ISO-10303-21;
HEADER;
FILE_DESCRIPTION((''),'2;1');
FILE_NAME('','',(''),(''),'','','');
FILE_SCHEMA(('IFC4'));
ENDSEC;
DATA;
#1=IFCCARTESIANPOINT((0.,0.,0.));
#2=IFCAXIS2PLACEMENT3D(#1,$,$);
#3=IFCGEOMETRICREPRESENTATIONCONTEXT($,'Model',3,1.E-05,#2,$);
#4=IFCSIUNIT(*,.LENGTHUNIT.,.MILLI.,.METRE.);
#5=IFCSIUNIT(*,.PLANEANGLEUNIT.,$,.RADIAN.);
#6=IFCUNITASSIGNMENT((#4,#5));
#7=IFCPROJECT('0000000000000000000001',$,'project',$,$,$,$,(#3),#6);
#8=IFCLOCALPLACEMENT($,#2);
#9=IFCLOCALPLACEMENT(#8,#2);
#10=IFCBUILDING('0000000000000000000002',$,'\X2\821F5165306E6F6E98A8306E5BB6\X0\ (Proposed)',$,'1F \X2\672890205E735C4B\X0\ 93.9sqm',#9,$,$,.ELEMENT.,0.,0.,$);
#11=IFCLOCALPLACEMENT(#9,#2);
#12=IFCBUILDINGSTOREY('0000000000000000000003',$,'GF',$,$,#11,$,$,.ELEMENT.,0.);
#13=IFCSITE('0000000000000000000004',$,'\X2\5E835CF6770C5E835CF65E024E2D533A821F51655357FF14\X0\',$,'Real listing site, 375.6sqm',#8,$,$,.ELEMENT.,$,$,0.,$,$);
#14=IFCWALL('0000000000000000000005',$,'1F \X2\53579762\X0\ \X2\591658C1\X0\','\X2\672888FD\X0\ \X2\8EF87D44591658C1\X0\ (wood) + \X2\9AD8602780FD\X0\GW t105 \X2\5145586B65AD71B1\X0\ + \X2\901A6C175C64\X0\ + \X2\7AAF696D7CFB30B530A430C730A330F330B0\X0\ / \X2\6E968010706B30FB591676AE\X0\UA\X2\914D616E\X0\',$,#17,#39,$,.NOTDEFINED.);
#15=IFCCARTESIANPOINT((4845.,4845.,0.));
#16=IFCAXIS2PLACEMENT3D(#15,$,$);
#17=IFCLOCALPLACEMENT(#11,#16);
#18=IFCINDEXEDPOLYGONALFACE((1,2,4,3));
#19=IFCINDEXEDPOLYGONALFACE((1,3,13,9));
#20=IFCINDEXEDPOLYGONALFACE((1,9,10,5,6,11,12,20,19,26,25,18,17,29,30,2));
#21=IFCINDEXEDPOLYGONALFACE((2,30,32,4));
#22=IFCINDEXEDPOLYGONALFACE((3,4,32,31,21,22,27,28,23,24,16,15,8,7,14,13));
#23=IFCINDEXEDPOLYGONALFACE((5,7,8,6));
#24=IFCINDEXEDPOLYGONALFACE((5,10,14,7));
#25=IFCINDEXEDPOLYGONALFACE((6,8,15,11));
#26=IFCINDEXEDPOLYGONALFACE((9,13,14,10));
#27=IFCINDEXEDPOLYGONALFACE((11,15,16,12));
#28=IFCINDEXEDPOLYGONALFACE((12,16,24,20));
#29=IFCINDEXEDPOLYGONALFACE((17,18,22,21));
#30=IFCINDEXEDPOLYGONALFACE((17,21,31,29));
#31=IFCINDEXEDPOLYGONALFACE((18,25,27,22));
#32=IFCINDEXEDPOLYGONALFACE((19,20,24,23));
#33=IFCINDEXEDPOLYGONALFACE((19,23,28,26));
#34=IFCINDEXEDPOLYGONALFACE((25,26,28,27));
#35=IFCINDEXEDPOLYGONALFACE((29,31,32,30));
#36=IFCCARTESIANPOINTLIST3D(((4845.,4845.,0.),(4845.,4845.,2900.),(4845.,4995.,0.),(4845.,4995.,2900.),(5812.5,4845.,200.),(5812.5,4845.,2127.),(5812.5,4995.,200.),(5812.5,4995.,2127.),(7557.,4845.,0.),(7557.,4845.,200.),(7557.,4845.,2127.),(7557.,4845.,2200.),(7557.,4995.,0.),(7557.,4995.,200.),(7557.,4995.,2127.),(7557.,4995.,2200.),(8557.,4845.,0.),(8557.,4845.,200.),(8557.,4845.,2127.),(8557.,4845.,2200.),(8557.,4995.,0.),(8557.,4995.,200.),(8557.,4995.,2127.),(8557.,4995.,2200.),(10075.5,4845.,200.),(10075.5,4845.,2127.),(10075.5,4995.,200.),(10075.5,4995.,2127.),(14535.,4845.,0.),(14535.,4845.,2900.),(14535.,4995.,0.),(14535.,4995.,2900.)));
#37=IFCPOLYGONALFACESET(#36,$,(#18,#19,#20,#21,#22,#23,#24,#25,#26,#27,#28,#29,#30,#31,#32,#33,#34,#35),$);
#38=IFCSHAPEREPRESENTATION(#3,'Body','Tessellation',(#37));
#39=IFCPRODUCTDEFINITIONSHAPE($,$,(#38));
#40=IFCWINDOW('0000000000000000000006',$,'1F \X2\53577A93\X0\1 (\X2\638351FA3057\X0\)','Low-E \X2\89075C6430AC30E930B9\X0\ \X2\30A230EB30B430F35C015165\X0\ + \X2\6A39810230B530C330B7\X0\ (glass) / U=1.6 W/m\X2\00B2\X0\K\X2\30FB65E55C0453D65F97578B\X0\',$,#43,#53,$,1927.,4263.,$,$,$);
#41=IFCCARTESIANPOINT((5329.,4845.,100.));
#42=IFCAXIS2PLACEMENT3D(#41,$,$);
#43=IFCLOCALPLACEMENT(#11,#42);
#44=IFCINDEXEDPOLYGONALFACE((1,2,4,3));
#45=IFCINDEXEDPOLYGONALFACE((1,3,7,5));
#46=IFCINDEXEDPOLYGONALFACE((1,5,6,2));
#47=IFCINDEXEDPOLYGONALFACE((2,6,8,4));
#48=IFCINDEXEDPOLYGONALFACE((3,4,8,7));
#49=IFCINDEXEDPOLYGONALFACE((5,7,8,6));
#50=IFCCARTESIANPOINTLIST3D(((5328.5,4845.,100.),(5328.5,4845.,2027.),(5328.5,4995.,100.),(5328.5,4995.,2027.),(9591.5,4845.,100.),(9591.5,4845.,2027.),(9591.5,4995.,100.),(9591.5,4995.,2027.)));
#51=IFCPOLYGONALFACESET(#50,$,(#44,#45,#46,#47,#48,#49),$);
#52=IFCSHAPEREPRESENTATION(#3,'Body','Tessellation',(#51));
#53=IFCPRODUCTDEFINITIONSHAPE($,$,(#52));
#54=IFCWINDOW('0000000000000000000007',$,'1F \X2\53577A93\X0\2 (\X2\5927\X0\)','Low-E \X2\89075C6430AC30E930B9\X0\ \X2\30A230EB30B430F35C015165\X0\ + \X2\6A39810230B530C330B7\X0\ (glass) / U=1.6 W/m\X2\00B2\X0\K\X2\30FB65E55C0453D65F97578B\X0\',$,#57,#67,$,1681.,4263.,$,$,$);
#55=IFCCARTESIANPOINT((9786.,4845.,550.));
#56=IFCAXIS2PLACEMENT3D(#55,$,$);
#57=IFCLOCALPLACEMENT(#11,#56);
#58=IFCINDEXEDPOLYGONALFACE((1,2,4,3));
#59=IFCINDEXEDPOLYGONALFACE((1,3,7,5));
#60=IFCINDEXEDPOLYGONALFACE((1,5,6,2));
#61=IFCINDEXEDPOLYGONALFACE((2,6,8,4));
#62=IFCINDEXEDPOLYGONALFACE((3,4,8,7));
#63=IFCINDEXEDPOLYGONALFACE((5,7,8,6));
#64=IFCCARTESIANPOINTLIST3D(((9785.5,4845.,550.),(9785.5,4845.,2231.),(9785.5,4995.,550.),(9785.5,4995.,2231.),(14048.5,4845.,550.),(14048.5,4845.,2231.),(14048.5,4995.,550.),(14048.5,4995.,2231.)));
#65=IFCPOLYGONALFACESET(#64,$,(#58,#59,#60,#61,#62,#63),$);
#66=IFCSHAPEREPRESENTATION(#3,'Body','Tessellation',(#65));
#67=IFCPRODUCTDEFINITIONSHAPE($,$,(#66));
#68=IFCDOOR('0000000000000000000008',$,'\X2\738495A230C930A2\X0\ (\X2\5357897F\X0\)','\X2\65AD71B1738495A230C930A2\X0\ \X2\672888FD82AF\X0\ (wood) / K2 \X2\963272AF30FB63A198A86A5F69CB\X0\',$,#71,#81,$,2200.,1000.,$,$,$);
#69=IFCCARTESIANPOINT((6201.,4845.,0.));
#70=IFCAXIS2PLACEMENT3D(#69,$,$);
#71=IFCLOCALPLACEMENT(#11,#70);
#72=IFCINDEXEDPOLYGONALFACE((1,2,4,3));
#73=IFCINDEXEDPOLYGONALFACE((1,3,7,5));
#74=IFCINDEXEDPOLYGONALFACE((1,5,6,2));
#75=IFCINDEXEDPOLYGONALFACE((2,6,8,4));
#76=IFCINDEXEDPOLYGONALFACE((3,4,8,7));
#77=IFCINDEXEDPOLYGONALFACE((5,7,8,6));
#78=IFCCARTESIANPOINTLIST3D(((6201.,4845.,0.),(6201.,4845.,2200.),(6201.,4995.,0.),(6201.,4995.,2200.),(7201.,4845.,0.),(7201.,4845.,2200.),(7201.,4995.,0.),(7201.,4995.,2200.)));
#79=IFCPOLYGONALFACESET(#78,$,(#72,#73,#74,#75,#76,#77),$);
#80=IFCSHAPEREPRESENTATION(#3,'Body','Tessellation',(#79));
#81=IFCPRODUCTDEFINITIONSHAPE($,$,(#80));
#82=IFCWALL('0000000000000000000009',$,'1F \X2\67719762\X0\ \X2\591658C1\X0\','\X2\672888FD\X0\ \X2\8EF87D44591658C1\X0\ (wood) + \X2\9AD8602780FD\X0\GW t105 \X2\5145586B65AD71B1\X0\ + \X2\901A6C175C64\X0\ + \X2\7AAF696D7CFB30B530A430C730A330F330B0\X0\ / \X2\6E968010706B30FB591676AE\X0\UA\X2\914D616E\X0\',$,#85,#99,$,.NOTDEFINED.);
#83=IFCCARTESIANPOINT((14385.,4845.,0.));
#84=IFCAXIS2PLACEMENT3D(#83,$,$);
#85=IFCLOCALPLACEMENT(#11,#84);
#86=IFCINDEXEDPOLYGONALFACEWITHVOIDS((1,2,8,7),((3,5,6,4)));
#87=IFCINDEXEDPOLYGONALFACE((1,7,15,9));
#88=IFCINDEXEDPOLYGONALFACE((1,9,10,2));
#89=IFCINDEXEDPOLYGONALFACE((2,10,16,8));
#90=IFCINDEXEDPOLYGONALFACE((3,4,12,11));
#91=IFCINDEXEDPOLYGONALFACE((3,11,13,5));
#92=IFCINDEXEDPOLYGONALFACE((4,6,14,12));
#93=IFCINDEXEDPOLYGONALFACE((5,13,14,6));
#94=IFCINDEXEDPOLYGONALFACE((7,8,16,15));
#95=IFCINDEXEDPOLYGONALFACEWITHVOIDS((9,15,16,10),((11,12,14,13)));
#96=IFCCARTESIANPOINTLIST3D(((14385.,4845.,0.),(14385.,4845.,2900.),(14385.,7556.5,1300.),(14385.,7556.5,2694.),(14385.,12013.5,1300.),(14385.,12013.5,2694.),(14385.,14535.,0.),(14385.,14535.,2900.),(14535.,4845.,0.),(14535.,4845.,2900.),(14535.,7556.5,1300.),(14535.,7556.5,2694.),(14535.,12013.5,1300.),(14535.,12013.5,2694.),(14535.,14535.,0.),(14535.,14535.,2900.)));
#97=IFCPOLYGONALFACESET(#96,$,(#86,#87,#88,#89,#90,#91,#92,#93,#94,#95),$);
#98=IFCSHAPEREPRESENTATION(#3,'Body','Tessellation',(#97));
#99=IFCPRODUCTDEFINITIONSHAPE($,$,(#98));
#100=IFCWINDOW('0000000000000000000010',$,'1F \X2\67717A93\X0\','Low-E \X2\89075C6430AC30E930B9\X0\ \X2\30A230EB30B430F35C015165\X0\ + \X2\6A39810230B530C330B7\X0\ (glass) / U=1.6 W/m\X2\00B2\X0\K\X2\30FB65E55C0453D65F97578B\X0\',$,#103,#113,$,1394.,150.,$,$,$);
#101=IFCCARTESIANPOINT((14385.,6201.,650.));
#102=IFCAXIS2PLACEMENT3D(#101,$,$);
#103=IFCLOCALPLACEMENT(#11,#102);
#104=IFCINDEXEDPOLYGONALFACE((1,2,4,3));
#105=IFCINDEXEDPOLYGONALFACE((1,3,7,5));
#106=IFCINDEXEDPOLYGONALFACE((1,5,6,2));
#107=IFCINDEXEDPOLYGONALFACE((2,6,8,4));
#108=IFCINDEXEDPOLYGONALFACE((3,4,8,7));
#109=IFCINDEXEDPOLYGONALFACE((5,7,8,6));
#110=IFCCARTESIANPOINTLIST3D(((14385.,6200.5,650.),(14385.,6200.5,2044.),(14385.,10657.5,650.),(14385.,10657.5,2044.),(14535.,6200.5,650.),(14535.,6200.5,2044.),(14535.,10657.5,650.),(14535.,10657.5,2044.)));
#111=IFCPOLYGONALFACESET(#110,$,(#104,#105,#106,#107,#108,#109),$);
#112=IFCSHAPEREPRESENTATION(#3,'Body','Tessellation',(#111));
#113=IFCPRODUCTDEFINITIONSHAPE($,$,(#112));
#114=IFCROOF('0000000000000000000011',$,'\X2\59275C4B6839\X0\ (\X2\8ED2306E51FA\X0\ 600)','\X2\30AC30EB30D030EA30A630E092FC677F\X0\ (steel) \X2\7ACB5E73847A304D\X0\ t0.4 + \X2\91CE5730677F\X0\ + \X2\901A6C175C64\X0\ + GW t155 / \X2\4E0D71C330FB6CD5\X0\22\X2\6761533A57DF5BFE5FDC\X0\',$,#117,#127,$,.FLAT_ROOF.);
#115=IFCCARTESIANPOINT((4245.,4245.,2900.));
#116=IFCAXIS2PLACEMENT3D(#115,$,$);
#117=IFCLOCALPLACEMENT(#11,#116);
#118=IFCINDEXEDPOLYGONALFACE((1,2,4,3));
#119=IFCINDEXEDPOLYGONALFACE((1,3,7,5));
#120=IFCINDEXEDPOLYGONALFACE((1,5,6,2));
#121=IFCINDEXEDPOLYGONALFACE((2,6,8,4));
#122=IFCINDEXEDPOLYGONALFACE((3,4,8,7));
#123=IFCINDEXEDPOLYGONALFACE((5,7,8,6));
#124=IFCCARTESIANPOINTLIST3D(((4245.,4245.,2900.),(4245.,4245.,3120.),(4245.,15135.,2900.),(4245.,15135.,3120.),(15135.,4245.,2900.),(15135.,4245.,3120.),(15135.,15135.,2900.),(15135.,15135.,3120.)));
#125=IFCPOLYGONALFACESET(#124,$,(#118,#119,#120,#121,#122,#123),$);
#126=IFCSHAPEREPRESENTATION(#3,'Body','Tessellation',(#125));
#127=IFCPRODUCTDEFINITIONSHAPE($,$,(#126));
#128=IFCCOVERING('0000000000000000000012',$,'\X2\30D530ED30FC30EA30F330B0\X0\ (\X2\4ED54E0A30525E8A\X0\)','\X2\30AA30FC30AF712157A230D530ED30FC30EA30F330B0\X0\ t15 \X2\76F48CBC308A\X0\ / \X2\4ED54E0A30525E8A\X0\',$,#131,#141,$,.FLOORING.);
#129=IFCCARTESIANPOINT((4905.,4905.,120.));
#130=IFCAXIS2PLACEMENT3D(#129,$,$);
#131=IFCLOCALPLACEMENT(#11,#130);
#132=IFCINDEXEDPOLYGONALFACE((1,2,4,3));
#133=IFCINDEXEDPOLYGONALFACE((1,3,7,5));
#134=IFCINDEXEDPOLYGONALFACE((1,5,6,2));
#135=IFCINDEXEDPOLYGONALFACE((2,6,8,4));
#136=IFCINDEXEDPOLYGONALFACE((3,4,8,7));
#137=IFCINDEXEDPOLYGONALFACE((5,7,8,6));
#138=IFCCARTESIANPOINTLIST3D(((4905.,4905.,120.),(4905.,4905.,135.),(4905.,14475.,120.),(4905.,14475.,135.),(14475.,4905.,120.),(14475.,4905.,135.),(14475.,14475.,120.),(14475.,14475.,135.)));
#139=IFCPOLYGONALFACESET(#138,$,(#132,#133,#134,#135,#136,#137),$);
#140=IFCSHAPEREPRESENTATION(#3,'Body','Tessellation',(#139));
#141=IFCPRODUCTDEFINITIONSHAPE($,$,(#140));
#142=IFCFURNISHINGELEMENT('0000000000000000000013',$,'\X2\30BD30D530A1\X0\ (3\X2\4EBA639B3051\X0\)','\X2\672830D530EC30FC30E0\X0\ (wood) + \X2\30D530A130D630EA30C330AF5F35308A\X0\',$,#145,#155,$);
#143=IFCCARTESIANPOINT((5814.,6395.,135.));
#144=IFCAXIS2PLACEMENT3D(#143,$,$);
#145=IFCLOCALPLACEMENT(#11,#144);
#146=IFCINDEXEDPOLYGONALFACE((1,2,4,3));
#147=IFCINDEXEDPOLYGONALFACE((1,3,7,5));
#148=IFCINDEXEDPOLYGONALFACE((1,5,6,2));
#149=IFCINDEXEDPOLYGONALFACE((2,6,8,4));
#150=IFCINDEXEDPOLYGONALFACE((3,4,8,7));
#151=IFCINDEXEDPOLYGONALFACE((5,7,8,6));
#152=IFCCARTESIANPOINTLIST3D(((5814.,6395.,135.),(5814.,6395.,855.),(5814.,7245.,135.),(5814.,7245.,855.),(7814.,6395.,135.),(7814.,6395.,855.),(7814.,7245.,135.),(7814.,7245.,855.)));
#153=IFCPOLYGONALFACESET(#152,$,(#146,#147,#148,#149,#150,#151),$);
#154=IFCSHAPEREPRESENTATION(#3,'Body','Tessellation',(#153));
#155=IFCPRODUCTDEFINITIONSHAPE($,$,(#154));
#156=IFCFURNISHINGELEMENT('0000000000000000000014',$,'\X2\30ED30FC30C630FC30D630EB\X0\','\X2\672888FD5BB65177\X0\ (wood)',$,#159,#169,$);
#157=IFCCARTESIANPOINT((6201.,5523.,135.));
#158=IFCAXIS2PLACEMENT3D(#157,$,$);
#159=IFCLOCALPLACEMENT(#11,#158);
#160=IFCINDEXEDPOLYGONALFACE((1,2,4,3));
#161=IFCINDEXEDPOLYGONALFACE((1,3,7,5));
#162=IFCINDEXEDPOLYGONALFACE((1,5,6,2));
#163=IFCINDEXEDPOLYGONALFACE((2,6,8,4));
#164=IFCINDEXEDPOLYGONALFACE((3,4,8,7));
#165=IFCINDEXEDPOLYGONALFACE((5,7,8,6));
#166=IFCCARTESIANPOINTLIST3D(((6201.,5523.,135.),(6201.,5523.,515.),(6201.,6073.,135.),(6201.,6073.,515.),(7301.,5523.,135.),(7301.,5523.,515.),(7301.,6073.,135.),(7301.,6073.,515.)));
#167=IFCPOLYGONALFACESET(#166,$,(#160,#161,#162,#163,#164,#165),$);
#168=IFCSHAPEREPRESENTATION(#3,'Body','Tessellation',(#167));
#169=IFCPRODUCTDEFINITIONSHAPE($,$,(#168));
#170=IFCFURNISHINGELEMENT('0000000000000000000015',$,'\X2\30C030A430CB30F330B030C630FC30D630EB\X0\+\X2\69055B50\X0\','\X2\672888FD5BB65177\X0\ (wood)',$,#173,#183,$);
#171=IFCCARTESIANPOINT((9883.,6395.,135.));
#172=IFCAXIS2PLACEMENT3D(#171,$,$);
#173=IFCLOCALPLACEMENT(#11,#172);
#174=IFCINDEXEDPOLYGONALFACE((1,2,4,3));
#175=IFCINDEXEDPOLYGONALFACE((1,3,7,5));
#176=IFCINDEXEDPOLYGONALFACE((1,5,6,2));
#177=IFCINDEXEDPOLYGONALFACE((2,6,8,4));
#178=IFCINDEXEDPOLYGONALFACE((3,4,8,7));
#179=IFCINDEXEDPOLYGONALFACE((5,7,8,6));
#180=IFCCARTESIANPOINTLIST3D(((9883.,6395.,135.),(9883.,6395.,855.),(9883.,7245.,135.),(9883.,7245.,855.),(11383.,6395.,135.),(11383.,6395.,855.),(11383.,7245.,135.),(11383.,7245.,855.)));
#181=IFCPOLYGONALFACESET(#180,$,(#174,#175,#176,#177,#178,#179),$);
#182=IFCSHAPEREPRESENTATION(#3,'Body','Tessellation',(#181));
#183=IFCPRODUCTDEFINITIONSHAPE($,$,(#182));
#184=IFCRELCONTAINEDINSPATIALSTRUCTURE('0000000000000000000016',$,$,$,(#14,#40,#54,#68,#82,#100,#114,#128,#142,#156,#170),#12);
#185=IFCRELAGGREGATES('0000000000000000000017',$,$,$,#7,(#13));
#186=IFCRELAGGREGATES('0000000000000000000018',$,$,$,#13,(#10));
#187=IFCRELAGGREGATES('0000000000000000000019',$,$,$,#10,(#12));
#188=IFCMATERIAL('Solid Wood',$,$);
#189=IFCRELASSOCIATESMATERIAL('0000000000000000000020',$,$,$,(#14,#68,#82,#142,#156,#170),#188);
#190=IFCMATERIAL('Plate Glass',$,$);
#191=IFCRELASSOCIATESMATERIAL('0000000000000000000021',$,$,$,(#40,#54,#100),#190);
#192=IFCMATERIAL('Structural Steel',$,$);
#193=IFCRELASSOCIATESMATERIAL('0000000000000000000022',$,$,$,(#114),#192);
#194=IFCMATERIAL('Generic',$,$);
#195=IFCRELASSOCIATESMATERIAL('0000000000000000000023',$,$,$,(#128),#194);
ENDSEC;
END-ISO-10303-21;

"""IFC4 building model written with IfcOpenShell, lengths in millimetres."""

from ifc_helpers import new_model, si_unit, frame, frame_2d, origin, place, context, project, spatial, rectangle, extrude, material, element, fill, save


model = new_model("IFC4")

# Units and contexts
model_context = context("Model", 3, precision=1e-05, world=origin())
ifc_project = project(units=[si_unit("LENGTHUNIT", "METRE", prefix="MILLI"), si_unit("PLANEANGLEUNIT", "RADIAN")], contexts=[model_context])

# Site, building, storey
site_placement = place(None, origin())
site = spatial("IfcSite", under=ifc_project, at=site_placement, Name="広島県広島市中区舟入南４", ObjectType="Real listing site, 375.6sqm", CompositionType="ELEMENT", RefElevation=0.0)
building_placement = place(site_placement, origin())
building = spatial("IfcBuilding", under=site, at=building_placement, Name="舟入の潮風の家 (Proposed)", ObjectType="1F 木造平屋 93.9sqm", CompositionType="ELEMENT", ElevationOfRefHeight=0.0, ElevationOfTerrain=0.0)
storey_placement = place(building_placement, origin())
storey = spatial("IfcBuildingStorey", under=building, at=storey_placement, Name="GF", CompositionType="ELEMENT", Elevation=0.0)

# Shared definitions
ifc_material_1 = material(Name="Solid Wood")

# Wall, openings, windows, door
wall_1_placement = place(storey_placement, frame((4845.0, 4845.0, 0.0)))
wall_1 = element("IfcWall", 1, at=wall_1_placement, inside=storey, material=ifc_material_1, Name="1F 南面 外壁", Description="木製 軸組外壁 (wood) + 高性能GW t105 充填断熱 + 通気層 + 窯業系サイディング / 準耐火・外皮UA配慮", PredefinedType="NOTDEFINED", context=model_context, shape_type="SweptSolid", body=[
    extrude(rectangle(XDim=9690.0, YDim=150.0, at=frame_2d((4845.0, 75.0))), frame((4845.0, 4845.0, 0.0)), (0.0, 0.0, 1.0), 2900.0),
])
opening_1_placement = place(storey_placement, frame((5329.0, 4845.0, 100.0)))
opening_1 = element("IfcOpeningElement", 2, at=opening_1_placement, cuts=wall_1, PredefinedType="NOTDEFINED", context=model_context, shape_type="SweptSolid", body=[
    extrude(rectangle(XDim=4263.0, YDim=150.0, at=frame_2d((2131.0, 75.0))), frame((5329.0, 4845.0, 100.0)), (0.0, 0.0, 1.0), 1927.0),
])
opening_2_placement = place(storey_placement, frame((9786.0, 4845.0, 550.0)))
opening_2 = element("IfcOpeningElement", 3, at=opening_2_placement, cuts=wall_1, PredefinedType="NOTDEFINED", context=model_context, shape_type="SweptSolid", body=[
    extrude(rectangle(XDim=4263.0, YDim=150.0, at=frame_2d((2131.0, 75.0))), frame((9786.0, 4845.0, 550.0)), (0.0, 0.0, 1.0), 1681.0),
])
opening_3_placement = place(storey_placement, frame((6201.0, 4845.0, 0.0)))
opening_3 = element("IfcOpeningElement", 4, at=opening_3_placement, cuts=wall_1, PredefinedType="NOTDEFINED", context=model_context, shape_type="SweptSolid", body=[
    extrude(rectangle(XDim=1000.0, YDim=150.0, at=frame_2d((500.0, 75.0))), frame((6201.0, 4845.0, 0.0)), (0.0, 0.0, 1.0), 2200.0),
])
ifc_material_2 = material(Name="Plate Glass")
window_1_placement = place(storey_placement, frame((5329.0, 4845.0, 100.0)))
window_1 = element("IfcWindow", 5, at=window_1_placement, inside=storey, material=ifc_material_2, Name="1F 南窓1 (掃出し)", Description="Low-E 複層ガラス アルゴン封入 + 樹脂サッシ (glass) / U=1.6 W/m²K・日射取得型", OverallHeight=1927.0, OverallWidth=4263.0, context=model_context, shape_type="SweptSolid", body=[
    extrude(rectangle(XDim=4263.0, YDim=150.0, at=frame_2d((2131.0, 75.0))), frame((5329.0, 4845.0, 100.0)), (0.0, 0.0, 1.0), 1927.0),
])
fill(opening_1, window_1)
window_2_placement = place(storey_placement, frame((9786.0, 4845.0, 550.0)))
window_2 = element("IfcWindow", 6, at=window_2_placement, inside=storey, material=ifc_material_2, Name="1F 南窓2 (大)", Description="Low-E 複層ガラス アルゴン封入 + 樹脂サッシ (glass) / U=1.6 W/m²K・日射取得型", OverallHeight=1681.0, OverallWidth=4263.0, context=model_context, shape_type="SweptSolid", body=[
    extrude(rectangle(XDim=4263.0, YDim=150.0, at=frame_2d((2131.0, 75.0))), frame((9786.0, 4845.0, 550.0)), (0.0, 0.0, 1.0), 1681.0),
])
fill(opening_2, window_2)
door_placement = place(storey_placement, frame((6201.0, 4845.0, 0.0)))
door = element("IfcDoor", 7, at=door_placement, inside=storey, material=ifc_material_1, Name="玄関ドア (南西)", Description="断熱玄関ドア 木製芯 (wood) / K2 防犯・採風機構", OverallHeight=2200.0, OverallWidth=1000.0, context=model_context, shape_type="SweptSolid", body=[
    extrude(rectangle(XDim=1000.0, YDim=150.0, at=frame_2d((500.0, 75.0))), frame((6201.0, 4845.0, 0.0)), (0.0, 0.0, 1.0), 2200.0),
])
fill(opening_3, door)

# Wall, opening, window
wall_2_placement = place(storey_placement, frame((14385.0, 4845.0, 0.0)))
wall_2 = element("IfcWall", 8, at=wall_2_placement, inside=storey, material=ifc_material_1, Name="1F 東面 外壁", Description="木製 軸組外壁 (wood) + 高性能GW t105 充填断熱 + 通気層 + 窯業系サイディング / 準耐火・外皮UA配慮", PredefinedType="NOTDEFINED", context=model_context, shape_type="SweptSolid", body=[
    extrude(rectangle(XDim=150.0, YDim=9690.0, at=frame_2d((75.0, 4845.0))), frame((14385.0, 4845.0, 0.0)), (0.0, 0.0, 1.0), 2900.0),
])
opening_4_placement = place(storey_placement, frame((14385.0, 6201.0, 650.0)))
opening_4 = element("IfcOpeningElement", 9, at=opening_4_placement, cuts=wall_2, PredefinedType="NOTDEFINED", context=model_context, shape_type="SweptSolid", body=[
    extrude(rectangle(XDim=150.0, YDim=4457.0, at=frame_2d((75.0, 2228.0))), frame((14385.0, 6201.0, 650.0)), (0.0, 0.0, 1.0), 1394.0),
])
window_3_placement = place(storey_placement, frame((14385.0, 6201.0, 650.0)))
window_3 = element("IfcWindow", 10, at=window_3_placement, inside=storey, material=ifc_material_2, Name="1F 東窓", Description="Low-E 複層ガラス アルゴン封入 + 樹脂サッシ (glass) / U=1.6 W/m²K・日射取得型", OverallHeight=1394.0, OverallWidth=150.0, context=model_context, shape_type="SweptSolid", body=[
    extrude(rectangle(XDim=150.0, YDim=4457.0, at=frame_2d((75.0, 2228.0))), frame((14385.0, 6201.0, 650.0)), (0.0, 0.0, 1.0), 1394.0),
])
fill(opening_4, window_3)

# Roof
ifc_material_3 = material(Name="Structural Steel")
roof_placement = place(storey_placement, frame((4245.0, 4245.0, 2900.0)))
element("IfcRoof", 11, at=roof_placement, inside=storey, material=ifc_material_3, Name="大屋根 (軒の出 600)", Description="ガルバリウム鋼板 (steel) 立平葺き t0.4 + 野地板 + 通気層 + GW t155 / 不燃・法22条区域対応", PredefinedType="FLAT_ROOF", context=model_context, shape_type="SweptSolid", body=[
    extrude(rectangle(XDim=10890.0, YDim=10890.0, at=frame_2d((5445.0, 5445.0))), frame((4245.0, 4245.0, 2900.0)), (0.0, 0.0, 1.0), 220.0),
])

# Covering
ifc_material_4 = material(Name="Generic")
covering_placement = place(storey_placement, frame((4905.0, 4905.0, 120.0)))
element("IfcCovering", 12, at=covering_placement, inside=storey, material=ifc_material_4, Name="フローリング (仕上げ床)", Description="オーク無垢フローリング t15 直貼り / 仕上げ床", PredefinedType="FLOORING", context=model_context, shape_type="SweptSolid", body=[
    extrude(rectangle(XDim=9570.0, YDim=9570.0, at=frame_2d((4785.0, 4785.0))), frame((4905.0, 4905.0, 120.0)), (0.0, 0.0, 1.0), 15.0),
])

# Furnishing elements
furnishing_1_placement = place(storey_placement, frame((5814.0, 6395.0, 135.0)))
element("IfcFurnishingElement", 13, at=furnishing_1_placement, inside=storey, material=ifc_material_1, Name="ソファ (3人掛け)", Description="木フレーム (wood) + ファブリック張り", context=model_context, shape_type="SweptSolid", body=[
    extrude(rectangle(XDim=2000.0, YDim=850.0, at=frame_2d((1000.0, 425.0))), frame((5814.0, 6395.0, 135.0)), (0.0, 0.0, 1.0), 720.0),
])
furnishing_2_placement = place(storey_placement, frame((6201.0, 5523.0, 135.0)))
element("IfcFurnishingElement", 14, at=furnishing_2_placement, inside=storey, material=ifc_material_1, Name="ローテーブル", Description="木製家具 (wood)", context=model_context, shape_type="SweptSolid", body=[
    extrude(rectangle(XDim=1100.0, YDim=550.0, at=frame_2d((550.0, 275.0))), frame((6201.0, 5523.0, 135.0)), (0.0, 0.0, 1.0), 380.0),
])
furnishing_3_placement = place(storey_placement, frame((9883.0, 6395.0, 135.0)))
element("IfcFurnishingElement", 15, at=furnishing_3_placement, inside=storey, material=ifc_material_1, Name="ダイニングテーブル+椅子", Description="木製家具 (wood)", context=model_context, shape_type="SweptSolid", body=[
    extrude(rectangle(XDim=1500.0, YDim=850.0, at=frame_2d((750.0, 425.0))), frame((9883.0, 6395.0, 135.0)), (0.0, 0.0, 1.0), 720.0),
])

save(model, "model.ifc")
